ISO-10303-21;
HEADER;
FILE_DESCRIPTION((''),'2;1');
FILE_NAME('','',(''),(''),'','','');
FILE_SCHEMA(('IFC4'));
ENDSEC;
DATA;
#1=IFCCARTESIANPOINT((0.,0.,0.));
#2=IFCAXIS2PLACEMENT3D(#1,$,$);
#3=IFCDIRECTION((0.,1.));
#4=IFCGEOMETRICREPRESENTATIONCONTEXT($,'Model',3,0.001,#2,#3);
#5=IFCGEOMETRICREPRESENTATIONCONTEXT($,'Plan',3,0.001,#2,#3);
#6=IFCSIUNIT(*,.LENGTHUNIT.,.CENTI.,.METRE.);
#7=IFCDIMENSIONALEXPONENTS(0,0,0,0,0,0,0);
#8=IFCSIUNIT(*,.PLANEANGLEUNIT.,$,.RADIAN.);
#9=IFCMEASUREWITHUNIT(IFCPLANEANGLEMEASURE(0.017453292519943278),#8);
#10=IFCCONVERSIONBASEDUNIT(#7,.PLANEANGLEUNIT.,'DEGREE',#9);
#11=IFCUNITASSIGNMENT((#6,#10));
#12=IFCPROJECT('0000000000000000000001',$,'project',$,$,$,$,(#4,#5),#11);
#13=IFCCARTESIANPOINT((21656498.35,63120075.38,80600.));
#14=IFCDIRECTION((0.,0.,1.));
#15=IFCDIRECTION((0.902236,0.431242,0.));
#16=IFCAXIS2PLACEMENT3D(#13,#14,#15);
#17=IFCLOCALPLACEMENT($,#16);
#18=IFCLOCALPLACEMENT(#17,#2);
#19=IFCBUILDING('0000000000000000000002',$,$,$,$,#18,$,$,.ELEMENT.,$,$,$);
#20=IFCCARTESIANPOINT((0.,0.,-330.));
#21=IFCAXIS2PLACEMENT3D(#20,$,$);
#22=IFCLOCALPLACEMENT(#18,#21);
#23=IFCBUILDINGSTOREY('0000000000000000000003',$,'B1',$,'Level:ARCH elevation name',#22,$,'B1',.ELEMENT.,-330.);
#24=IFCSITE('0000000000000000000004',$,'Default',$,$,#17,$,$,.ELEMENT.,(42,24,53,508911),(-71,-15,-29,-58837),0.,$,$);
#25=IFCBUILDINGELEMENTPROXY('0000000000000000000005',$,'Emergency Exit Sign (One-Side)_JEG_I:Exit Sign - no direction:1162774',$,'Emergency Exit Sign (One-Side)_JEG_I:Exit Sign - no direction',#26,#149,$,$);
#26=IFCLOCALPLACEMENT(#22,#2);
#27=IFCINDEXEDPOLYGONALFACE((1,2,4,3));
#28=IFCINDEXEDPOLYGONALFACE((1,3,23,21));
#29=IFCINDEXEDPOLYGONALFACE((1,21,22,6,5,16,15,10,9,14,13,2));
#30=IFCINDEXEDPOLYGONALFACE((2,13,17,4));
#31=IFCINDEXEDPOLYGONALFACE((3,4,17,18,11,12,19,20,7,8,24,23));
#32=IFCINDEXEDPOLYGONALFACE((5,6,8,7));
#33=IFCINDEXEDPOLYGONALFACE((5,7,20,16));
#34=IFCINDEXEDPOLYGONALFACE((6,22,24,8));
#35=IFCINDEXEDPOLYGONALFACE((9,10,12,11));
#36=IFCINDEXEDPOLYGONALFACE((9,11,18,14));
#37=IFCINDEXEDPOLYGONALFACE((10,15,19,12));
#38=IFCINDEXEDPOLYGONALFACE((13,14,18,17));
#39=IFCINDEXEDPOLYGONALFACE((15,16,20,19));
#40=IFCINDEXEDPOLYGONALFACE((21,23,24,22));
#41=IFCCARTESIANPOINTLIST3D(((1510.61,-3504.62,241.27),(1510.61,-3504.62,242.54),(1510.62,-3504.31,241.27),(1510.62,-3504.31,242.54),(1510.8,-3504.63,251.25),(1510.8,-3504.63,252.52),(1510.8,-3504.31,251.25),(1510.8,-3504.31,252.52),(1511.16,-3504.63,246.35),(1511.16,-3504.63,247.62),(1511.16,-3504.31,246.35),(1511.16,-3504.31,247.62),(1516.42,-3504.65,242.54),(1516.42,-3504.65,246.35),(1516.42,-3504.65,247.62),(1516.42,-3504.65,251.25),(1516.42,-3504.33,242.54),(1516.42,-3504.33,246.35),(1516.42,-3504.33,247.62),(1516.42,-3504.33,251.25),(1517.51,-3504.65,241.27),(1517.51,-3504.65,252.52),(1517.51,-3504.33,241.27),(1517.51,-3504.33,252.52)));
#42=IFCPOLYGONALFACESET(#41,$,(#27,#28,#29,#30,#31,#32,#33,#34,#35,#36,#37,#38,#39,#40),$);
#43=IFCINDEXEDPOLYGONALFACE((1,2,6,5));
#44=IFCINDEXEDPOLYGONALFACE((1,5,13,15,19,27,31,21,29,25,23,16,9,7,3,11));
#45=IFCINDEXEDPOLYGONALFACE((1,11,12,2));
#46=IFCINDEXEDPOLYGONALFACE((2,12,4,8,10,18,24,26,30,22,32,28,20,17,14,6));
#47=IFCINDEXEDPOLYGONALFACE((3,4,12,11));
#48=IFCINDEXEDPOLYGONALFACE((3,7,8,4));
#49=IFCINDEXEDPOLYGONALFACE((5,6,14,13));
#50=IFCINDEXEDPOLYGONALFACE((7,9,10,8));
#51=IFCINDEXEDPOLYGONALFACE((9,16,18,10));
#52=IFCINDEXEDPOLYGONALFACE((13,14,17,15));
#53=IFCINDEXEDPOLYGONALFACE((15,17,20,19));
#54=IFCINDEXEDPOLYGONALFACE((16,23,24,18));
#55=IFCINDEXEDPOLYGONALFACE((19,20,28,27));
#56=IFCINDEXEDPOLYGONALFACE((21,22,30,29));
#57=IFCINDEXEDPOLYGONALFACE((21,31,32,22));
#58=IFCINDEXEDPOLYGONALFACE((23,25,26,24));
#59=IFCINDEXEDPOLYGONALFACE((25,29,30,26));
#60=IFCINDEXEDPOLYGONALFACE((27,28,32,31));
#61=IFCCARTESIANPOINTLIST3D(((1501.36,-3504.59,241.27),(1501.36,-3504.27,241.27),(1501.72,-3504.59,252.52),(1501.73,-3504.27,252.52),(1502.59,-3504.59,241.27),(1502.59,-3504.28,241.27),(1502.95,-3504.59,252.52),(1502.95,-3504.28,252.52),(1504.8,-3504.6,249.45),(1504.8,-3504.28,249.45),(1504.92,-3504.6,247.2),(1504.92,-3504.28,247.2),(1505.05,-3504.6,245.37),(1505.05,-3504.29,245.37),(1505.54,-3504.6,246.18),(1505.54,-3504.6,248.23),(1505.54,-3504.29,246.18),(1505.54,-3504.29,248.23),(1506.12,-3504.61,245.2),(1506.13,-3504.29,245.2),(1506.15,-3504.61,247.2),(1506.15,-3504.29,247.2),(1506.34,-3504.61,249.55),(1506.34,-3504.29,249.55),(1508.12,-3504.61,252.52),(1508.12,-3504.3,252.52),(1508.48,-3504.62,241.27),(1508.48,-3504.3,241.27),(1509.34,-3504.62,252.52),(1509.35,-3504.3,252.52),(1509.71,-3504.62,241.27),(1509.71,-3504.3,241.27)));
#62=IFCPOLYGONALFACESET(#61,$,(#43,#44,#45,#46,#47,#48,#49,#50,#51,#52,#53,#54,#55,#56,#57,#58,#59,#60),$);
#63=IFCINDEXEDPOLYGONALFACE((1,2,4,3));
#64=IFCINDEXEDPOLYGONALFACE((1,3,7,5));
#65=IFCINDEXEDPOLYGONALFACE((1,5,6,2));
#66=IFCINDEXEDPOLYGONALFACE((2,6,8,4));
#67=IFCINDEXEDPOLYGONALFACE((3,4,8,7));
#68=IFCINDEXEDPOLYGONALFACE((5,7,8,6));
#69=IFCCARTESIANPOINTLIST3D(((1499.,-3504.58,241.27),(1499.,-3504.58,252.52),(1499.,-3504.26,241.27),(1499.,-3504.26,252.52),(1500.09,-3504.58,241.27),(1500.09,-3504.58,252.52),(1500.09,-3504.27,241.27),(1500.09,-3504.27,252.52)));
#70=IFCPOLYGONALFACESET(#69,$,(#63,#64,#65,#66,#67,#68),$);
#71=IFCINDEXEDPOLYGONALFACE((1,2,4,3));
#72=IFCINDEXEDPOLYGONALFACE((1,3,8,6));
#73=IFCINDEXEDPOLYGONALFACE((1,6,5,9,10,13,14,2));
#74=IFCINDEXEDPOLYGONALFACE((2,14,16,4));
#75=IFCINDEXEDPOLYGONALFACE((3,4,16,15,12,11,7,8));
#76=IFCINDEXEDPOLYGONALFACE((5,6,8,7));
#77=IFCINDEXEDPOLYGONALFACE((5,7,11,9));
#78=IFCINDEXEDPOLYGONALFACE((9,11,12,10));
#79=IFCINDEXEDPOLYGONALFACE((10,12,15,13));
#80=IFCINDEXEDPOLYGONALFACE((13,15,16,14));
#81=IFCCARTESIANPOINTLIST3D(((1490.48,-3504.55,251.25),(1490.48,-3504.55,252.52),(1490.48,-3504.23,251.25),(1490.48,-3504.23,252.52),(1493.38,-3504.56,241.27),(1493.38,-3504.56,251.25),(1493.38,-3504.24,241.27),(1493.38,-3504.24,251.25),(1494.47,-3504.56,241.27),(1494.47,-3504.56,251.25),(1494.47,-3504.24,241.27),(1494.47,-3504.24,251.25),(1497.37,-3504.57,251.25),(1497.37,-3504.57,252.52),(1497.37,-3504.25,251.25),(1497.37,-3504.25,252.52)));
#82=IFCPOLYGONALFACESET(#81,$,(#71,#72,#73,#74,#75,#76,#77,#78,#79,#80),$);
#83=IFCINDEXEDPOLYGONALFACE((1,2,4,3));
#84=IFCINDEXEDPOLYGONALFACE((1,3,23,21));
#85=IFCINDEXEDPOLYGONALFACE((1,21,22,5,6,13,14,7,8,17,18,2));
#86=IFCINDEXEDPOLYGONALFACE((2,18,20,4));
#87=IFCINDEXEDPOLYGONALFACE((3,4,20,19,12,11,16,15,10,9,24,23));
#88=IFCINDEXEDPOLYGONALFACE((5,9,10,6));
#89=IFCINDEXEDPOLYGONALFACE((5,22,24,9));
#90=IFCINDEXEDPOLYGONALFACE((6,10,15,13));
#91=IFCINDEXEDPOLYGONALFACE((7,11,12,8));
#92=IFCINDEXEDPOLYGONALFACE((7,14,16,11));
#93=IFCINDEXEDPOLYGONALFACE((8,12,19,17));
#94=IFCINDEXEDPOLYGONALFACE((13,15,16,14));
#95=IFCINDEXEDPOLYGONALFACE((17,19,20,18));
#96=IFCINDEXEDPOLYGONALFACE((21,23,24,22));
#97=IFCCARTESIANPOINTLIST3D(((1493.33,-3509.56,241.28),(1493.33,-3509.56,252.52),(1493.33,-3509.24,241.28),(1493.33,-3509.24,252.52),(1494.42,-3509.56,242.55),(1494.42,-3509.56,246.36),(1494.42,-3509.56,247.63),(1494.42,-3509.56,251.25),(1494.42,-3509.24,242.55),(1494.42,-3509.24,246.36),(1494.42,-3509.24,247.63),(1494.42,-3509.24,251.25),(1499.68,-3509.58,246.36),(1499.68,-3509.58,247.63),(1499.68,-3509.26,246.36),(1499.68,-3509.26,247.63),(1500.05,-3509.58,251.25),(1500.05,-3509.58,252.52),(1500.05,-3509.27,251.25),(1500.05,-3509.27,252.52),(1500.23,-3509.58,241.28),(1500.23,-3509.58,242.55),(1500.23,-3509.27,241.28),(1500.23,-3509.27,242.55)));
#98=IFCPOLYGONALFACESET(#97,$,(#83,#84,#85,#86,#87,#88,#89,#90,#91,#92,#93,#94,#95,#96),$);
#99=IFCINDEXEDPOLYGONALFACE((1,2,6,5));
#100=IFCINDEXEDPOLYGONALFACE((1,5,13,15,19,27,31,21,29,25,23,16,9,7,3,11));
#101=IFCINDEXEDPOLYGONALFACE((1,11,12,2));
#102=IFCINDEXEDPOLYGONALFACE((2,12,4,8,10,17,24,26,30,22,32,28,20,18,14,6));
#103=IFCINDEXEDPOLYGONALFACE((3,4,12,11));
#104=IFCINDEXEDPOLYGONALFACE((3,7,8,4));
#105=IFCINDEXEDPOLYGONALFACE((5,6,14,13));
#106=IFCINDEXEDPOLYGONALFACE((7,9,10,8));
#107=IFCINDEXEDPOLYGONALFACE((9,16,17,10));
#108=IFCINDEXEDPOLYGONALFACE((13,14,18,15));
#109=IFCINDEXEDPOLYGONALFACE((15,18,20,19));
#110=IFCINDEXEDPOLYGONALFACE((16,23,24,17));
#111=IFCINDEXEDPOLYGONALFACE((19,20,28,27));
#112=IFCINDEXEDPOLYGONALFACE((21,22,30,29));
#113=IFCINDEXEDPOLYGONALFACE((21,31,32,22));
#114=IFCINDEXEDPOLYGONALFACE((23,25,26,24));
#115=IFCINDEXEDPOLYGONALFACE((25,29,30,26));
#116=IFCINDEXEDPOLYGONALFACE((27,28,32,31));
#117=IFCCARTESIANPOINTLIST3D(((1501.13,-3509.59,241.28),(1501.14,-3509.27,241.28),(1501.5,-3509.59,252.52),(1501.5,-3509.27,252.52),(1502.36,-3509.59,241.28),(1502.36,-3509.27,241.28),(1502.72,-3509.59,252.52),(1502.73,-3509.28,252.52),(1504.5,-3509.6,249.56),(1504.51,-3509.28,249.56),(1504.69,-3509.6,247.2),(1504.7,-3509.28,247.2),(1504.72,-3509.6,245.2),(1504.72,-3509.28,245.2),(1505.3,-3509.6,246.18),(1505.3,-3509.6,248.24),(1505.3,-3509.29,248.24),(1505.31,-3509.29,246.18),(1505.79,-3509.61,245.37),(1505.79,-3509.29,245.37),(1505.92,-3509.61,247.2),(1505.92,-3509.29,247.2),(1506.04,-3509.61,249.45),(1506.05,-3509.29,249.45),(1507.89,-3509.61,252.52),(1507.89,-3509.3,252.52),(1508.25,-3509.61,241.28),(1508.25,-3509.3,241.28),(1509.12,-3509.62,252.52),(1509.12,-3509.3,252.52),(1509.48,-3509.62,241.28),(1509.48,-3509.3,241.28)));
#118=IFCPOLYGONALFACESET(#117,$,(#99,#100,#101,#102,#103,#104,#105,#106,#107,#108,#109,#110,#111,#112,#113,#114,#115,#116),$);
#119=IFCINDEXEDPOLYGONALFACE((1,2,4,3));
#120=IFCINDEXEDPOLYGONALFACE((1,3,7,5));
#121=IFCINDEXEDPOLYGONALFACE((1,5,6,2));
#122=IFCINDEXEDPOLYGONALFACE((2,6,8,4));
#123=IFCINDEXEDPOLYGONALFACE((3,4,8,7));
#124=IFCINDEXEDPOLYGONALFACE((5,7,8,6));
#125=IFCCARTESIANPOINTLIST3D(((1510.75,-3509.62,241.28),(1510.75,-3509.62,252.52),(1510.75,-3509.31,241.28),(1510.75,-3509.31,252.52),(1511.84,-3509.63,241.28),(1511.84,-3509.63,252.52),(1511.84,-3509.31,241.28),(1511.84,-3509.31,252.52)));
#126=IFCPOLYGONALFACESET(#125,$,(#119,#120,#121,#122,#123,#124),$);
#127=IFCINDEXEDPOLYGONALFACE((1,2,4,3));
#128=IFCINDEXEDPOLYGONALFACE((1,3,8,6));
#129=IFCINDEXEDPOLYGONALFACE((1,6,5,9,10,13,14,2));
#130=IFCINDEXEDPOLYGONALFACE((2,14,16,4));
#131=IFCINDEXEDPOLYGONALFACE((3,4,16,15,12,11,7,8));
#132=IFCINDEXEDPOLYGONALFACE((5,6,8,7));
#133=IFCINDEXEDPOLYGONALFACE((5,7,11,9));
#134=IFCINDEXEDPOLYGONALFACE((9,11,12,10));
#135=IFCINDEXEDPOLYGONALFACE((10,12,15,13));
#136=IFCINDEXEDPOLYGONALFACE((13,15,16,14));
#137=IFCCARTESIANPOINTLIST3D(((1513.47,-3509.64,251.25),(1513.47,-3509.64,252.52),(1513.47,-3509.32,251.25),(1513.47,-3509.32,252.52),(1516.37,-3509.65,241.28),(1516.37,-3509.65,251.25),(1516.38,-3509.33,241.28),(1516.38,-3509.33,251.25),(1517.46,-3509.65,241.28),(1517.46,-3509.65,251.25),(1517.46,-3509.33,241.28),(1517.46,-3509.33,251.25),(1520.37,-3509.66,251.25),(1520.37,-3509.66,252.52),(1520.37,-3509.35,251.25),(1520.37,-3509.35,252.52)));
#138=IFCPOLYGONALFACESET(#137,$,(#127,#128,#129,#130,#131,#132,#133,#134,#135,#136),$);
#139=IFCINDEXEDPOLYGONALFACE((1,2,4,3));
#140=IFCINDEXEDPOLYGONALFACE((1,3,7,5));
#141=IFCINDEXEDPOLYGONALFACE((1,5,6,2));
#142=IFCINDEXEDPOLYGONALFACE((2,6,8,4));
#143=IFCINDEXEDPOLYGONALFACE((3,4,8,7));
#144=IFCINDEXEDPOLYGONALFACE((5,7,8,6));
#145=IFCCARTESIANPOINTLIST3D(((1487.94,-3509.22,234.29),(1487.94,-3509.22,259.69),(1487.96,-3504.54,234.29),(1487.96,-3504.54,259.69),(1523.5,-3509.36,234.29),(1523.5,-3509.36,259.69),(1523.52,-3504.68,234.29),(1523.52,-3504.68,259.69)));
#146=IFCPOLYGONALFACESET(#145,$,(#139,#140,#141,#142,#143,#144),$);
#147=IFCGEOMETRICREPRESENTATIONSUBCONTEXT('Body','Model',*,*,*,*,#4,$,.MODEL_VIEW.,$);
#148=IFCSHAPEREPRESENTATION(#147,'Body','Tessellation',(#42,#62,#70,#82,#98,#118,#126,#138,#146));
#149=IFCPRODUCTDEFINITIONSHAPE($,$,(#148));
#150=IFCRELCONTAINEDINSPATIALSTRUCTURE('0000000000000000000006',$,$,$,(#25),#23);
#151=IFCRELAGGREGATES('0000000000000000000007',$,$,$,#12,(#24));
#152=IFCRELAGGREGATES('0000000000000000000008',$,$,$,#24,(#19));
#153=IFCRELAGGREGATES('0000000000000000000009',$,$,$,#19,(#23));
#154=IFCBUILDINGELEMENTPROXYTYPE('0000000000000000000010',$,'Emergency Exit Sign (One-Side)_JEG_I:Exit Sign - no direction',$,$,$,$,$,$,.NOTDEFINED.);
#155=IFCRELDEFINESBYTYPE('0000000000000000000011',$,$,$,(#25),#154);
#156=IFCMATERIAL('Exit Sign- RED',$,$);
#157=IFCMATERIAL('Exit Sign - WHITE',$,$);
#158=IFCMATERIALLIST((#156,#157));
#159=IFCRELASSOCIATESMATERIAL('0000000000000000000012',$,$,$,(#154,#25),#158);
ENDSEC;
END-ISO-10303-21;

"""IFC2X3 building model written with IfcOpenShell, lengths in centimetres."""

from ifc_helpers import new_model, entity, si_unit, converted_unit, direction, frame, frame_2d, origin, origin_2d_with_axis, place, context, subcontext, project, spatial, polyline, rectangle, outline, extrude, source, transform, mapped, material, material_list, type_object, type_shapes, element, save


model = new_model("IFC2X3")

# Units and contexts
model_context = context("Model", 3, precision=0.001, world=origin(), true_north=direction((0.0, 1.0)))
plan_context = context("Plan", 3, precision=0.001, world=origin(), true_north=direction((0.0, 1.0)))
body_context = subcontext(model_context, "Body", "Model", "MODEL_VIEW")
ifc_project = project(units=[si_unit("LENGTHUNIT", "METRE", prefix="CENTI"), converted_unit("PLANEANGLEUNIT", "DEGREE", entity("IfcPlaneAngleMeasure", 0.017453292519943278), si_unit("PLANEANGLEUNIT", "RADIAN"), dimensions=[0, 0, 0, 0, 0, 0, 0])], contexts=[model_context, plan_context])

# Site, building, storey
site_placement = place(None, frame((21656498.35, 63120075.38, 80600.0), z_axis=(0.0, 0.0, 1.0), x_axis=(0.902236, 0.431242, 0.0)))
site = spatial("IfcSite", under=ifc_project, at=site_placement, Name="Default", CompositionType="ELEMENT", RefLatitude=(42, 24, 53, 508911), RefLongitude=(-71, -15, -29, -58837), RefElevation=0.0)
building_placement = place(site_placement, origin())
building = spatial("IfcBuilding", under=site, at=building_placement, CompositionType="ELEMENT")
storey_placement = place(building_placement, frame((0.0, 0.0, -330.0)))
storey = spatial("IfcBuildingStorey", under=building, at=storey_placement, Name="B1", ObjectType="Level:ARCH elevation name", LongName="B1", CompositionType="ELEMENT", Elevation=-330.0)

# Shared definitions
ifc_material_1 = material(Name="Exit Sign - WHITE")
ifc_material_2 = material(Name="Exit Sign- RED")

# Building element proxy
ifc_material_list_1 = material_list([ifc_material_2, ifc_material_1])
building_element_proxy_type_1 = type_object("IfcBuildingElementProxyType", Name="Emergency Exit Sign (One-Side)_JEG_I:Exit Sign - no direction", PredefinedType="NOTDEFINED", material=ifc_material_list_1)
shared_shape_1 = source(origin(), body_context, "Body", "SweptSolid", [
    extrude(outline(polyline([(-5.65, -3.69), (5.59, -3.69), (5.59, 3.02), (4.32, 3.02), (4.32, -2.6), (0.7, -2.6), (0.7, 2.66), (-0.57, 2.66), (-0.57, -2.6), (-4.38, -2.6), (-4.38, 3.21), (-5.65, 3.21), (-5.65, -3.69)])), frame((-8.08, -5.22, 12.64), z_axis=(0.0, 1.0, 0.0), x_axis=(0.0, 0.0, 1.0)), (0.0, 0.0, 1.0), 0.32),
    extrude(outline(polyline([(-7.14, 0.57), (-6.5, -0.49), (-1.93, -0.48), (-0.78, -0.48), (-1.23, -1.32), (-3.47, -5.53), (-2.84, -6.59), (0.41, -0.48), (6.62, -0.48), (5.99, 0.57), (2.4, 0.57), (0.98, 0.58), (1.7, 1.94), (3.32, 5.0), (2.69, 6.05), (-0.22, 0.57), (-7.14, 0.57)])), frame((0.2, -5.22, 12.81), z_axis=(0.0, -1.0, 0.0), x_axis=(0.515099, 0.0, 0.857131)), (0.0, 0.0, -1.0), 0.32),
    extrude(rectangle(XDim=0.32, YDim=1.09, at=frame_2d((0.0, 0.0), x_axis=(1.0, 0.0))), frame((6.19, -5.06, 6.99), z_axis=(0.0, 0.0, 1.0), x_axis=(0.0, 1.0, 0.0)), (0.0, 0.0, 1.0), 11.25),
    extrude(outline(polyline([(-7.8, 0.54), (-7.8, -0.54), (2.18, -0.54), (2.18, -3.45), (3.45, -3.45), (3.45, 3.45), (2.18, 3.45), (2.18, 0.54), (-7.8, 0.54)])), frame((11.82, -5.22, 14.79), z_axis=(0.0, -1.0, 0.0), x_axis=(0.0, 0.0, 1.0)), (0.0, 0.0, -1.0), 0.32),
    extrude(outline(polyline([(-3.69, -5.65), (3.21, -5.65), (3.21, -4.38), (-2.6, -4.38), (-2.6, -0.57), (2.66, -0.57), (2.66, 0.7), (-2.6, 0.7), (-2.6, 4.32), (3.02, 4.32), (3.02, 5.59), (-3.69, 5.59), (-3.69, -5.65)])), frame((8.7, -0.22, 12.65), z_axis=(0.0, 1.0, 0.0), x_axis=(-1.0, 0.0, 0.0)), (0.0, 0.0, 1.0), 0.32),
    extrude(outline(polyline([(-4.16, -5.82), (-2.93, -5.82), (-0.58, -1.9), (0.01, -0.92), (0.5, -1.73), (2.96, -5.82), (4.18, -5.82), (0.62, 0.1), (3.82, 5.42), (2.59, 5.42), (0.75, 2.35), (0.01, 1.14), (-0.79, 2.46), (-2.57, 5.42), (-3.8, 5.42), (-0.6, 0.1), (-4.16, -5.82)])), frame((0.43, -0.22, 12.82), z_axis=(0.0, 1.0, 0.0), x_axis=(-1.0, 0.0, 0.0)), (0.0, 0.0, 1.0), 0.32),
    extrude(rectangle(XDim=0.32, YDim=1.09, at=origin_2d_with_axis()), frame((-5.57, -0.06, 6.99), z_axis=(0.0, 0.0, 1.0), x_axis=(0.0, -1.0, 0.0)), (0.0, 0.0, 1.0), 11.25),
    extrude(outline(polyline([(-0.54, -7.8), (0.54, -7.8), (0.54, 2.18), (3.45, 2.18), (3.45, 3.45), (-3.45, 3.45), (-3.45, 2.18), (-0.54, 2.18), (-0.54, -7.8)])), frame((-11.2, -0.22, 14.79), z_axis=(0.0, 1.0, 0.0), x_axis=(-1.0, 0.0, 0.0)), (0.0, 0.0, 1.0), 0.32),
    extrude(rectangle(XDim=4.68, YDim=35.56, at=origin_2d_with_axis()), frame((0.0, -2.56, 0.01), z_axis=(0.0, 0.0, 1.0), x_axis=(0.0, 1.0, 0.0)), (0.0, 0.0, 1.0), 25.4),
])
type_shapes(building_element_proxy_type_1, [shared_shape_1])
for number, where, z_axis, x_axis, name in (
    (1, (1505.72, -3509.51, 234.28), (0.0, 0.0, 1.0), (-0.999992, 0.00394, 0.0), "Emergency Exit Sign (One-Side)_JEG_I:Exit Sign - no direction:1162774"),
):
    element("IfcBuildingElementProxy", number, at=place(storey_placement, frame(where, z_axis=z_axis, x_axis=x_axis)), inside=storey, type_object=building_element_proxy_type_1, material=ifc_material_list_1, Name=name, ObjectType="Emergency Exit Sign (One-Side)_JEG_I:Exit Sign - no direction", context=body_context, shape_type="MappedRepresentation", body=[
        mapped(shared_shape_1, transform((0.0, 0.0, 0.0), scale=1.0)),
    ])

save(model, "model.ifc")
